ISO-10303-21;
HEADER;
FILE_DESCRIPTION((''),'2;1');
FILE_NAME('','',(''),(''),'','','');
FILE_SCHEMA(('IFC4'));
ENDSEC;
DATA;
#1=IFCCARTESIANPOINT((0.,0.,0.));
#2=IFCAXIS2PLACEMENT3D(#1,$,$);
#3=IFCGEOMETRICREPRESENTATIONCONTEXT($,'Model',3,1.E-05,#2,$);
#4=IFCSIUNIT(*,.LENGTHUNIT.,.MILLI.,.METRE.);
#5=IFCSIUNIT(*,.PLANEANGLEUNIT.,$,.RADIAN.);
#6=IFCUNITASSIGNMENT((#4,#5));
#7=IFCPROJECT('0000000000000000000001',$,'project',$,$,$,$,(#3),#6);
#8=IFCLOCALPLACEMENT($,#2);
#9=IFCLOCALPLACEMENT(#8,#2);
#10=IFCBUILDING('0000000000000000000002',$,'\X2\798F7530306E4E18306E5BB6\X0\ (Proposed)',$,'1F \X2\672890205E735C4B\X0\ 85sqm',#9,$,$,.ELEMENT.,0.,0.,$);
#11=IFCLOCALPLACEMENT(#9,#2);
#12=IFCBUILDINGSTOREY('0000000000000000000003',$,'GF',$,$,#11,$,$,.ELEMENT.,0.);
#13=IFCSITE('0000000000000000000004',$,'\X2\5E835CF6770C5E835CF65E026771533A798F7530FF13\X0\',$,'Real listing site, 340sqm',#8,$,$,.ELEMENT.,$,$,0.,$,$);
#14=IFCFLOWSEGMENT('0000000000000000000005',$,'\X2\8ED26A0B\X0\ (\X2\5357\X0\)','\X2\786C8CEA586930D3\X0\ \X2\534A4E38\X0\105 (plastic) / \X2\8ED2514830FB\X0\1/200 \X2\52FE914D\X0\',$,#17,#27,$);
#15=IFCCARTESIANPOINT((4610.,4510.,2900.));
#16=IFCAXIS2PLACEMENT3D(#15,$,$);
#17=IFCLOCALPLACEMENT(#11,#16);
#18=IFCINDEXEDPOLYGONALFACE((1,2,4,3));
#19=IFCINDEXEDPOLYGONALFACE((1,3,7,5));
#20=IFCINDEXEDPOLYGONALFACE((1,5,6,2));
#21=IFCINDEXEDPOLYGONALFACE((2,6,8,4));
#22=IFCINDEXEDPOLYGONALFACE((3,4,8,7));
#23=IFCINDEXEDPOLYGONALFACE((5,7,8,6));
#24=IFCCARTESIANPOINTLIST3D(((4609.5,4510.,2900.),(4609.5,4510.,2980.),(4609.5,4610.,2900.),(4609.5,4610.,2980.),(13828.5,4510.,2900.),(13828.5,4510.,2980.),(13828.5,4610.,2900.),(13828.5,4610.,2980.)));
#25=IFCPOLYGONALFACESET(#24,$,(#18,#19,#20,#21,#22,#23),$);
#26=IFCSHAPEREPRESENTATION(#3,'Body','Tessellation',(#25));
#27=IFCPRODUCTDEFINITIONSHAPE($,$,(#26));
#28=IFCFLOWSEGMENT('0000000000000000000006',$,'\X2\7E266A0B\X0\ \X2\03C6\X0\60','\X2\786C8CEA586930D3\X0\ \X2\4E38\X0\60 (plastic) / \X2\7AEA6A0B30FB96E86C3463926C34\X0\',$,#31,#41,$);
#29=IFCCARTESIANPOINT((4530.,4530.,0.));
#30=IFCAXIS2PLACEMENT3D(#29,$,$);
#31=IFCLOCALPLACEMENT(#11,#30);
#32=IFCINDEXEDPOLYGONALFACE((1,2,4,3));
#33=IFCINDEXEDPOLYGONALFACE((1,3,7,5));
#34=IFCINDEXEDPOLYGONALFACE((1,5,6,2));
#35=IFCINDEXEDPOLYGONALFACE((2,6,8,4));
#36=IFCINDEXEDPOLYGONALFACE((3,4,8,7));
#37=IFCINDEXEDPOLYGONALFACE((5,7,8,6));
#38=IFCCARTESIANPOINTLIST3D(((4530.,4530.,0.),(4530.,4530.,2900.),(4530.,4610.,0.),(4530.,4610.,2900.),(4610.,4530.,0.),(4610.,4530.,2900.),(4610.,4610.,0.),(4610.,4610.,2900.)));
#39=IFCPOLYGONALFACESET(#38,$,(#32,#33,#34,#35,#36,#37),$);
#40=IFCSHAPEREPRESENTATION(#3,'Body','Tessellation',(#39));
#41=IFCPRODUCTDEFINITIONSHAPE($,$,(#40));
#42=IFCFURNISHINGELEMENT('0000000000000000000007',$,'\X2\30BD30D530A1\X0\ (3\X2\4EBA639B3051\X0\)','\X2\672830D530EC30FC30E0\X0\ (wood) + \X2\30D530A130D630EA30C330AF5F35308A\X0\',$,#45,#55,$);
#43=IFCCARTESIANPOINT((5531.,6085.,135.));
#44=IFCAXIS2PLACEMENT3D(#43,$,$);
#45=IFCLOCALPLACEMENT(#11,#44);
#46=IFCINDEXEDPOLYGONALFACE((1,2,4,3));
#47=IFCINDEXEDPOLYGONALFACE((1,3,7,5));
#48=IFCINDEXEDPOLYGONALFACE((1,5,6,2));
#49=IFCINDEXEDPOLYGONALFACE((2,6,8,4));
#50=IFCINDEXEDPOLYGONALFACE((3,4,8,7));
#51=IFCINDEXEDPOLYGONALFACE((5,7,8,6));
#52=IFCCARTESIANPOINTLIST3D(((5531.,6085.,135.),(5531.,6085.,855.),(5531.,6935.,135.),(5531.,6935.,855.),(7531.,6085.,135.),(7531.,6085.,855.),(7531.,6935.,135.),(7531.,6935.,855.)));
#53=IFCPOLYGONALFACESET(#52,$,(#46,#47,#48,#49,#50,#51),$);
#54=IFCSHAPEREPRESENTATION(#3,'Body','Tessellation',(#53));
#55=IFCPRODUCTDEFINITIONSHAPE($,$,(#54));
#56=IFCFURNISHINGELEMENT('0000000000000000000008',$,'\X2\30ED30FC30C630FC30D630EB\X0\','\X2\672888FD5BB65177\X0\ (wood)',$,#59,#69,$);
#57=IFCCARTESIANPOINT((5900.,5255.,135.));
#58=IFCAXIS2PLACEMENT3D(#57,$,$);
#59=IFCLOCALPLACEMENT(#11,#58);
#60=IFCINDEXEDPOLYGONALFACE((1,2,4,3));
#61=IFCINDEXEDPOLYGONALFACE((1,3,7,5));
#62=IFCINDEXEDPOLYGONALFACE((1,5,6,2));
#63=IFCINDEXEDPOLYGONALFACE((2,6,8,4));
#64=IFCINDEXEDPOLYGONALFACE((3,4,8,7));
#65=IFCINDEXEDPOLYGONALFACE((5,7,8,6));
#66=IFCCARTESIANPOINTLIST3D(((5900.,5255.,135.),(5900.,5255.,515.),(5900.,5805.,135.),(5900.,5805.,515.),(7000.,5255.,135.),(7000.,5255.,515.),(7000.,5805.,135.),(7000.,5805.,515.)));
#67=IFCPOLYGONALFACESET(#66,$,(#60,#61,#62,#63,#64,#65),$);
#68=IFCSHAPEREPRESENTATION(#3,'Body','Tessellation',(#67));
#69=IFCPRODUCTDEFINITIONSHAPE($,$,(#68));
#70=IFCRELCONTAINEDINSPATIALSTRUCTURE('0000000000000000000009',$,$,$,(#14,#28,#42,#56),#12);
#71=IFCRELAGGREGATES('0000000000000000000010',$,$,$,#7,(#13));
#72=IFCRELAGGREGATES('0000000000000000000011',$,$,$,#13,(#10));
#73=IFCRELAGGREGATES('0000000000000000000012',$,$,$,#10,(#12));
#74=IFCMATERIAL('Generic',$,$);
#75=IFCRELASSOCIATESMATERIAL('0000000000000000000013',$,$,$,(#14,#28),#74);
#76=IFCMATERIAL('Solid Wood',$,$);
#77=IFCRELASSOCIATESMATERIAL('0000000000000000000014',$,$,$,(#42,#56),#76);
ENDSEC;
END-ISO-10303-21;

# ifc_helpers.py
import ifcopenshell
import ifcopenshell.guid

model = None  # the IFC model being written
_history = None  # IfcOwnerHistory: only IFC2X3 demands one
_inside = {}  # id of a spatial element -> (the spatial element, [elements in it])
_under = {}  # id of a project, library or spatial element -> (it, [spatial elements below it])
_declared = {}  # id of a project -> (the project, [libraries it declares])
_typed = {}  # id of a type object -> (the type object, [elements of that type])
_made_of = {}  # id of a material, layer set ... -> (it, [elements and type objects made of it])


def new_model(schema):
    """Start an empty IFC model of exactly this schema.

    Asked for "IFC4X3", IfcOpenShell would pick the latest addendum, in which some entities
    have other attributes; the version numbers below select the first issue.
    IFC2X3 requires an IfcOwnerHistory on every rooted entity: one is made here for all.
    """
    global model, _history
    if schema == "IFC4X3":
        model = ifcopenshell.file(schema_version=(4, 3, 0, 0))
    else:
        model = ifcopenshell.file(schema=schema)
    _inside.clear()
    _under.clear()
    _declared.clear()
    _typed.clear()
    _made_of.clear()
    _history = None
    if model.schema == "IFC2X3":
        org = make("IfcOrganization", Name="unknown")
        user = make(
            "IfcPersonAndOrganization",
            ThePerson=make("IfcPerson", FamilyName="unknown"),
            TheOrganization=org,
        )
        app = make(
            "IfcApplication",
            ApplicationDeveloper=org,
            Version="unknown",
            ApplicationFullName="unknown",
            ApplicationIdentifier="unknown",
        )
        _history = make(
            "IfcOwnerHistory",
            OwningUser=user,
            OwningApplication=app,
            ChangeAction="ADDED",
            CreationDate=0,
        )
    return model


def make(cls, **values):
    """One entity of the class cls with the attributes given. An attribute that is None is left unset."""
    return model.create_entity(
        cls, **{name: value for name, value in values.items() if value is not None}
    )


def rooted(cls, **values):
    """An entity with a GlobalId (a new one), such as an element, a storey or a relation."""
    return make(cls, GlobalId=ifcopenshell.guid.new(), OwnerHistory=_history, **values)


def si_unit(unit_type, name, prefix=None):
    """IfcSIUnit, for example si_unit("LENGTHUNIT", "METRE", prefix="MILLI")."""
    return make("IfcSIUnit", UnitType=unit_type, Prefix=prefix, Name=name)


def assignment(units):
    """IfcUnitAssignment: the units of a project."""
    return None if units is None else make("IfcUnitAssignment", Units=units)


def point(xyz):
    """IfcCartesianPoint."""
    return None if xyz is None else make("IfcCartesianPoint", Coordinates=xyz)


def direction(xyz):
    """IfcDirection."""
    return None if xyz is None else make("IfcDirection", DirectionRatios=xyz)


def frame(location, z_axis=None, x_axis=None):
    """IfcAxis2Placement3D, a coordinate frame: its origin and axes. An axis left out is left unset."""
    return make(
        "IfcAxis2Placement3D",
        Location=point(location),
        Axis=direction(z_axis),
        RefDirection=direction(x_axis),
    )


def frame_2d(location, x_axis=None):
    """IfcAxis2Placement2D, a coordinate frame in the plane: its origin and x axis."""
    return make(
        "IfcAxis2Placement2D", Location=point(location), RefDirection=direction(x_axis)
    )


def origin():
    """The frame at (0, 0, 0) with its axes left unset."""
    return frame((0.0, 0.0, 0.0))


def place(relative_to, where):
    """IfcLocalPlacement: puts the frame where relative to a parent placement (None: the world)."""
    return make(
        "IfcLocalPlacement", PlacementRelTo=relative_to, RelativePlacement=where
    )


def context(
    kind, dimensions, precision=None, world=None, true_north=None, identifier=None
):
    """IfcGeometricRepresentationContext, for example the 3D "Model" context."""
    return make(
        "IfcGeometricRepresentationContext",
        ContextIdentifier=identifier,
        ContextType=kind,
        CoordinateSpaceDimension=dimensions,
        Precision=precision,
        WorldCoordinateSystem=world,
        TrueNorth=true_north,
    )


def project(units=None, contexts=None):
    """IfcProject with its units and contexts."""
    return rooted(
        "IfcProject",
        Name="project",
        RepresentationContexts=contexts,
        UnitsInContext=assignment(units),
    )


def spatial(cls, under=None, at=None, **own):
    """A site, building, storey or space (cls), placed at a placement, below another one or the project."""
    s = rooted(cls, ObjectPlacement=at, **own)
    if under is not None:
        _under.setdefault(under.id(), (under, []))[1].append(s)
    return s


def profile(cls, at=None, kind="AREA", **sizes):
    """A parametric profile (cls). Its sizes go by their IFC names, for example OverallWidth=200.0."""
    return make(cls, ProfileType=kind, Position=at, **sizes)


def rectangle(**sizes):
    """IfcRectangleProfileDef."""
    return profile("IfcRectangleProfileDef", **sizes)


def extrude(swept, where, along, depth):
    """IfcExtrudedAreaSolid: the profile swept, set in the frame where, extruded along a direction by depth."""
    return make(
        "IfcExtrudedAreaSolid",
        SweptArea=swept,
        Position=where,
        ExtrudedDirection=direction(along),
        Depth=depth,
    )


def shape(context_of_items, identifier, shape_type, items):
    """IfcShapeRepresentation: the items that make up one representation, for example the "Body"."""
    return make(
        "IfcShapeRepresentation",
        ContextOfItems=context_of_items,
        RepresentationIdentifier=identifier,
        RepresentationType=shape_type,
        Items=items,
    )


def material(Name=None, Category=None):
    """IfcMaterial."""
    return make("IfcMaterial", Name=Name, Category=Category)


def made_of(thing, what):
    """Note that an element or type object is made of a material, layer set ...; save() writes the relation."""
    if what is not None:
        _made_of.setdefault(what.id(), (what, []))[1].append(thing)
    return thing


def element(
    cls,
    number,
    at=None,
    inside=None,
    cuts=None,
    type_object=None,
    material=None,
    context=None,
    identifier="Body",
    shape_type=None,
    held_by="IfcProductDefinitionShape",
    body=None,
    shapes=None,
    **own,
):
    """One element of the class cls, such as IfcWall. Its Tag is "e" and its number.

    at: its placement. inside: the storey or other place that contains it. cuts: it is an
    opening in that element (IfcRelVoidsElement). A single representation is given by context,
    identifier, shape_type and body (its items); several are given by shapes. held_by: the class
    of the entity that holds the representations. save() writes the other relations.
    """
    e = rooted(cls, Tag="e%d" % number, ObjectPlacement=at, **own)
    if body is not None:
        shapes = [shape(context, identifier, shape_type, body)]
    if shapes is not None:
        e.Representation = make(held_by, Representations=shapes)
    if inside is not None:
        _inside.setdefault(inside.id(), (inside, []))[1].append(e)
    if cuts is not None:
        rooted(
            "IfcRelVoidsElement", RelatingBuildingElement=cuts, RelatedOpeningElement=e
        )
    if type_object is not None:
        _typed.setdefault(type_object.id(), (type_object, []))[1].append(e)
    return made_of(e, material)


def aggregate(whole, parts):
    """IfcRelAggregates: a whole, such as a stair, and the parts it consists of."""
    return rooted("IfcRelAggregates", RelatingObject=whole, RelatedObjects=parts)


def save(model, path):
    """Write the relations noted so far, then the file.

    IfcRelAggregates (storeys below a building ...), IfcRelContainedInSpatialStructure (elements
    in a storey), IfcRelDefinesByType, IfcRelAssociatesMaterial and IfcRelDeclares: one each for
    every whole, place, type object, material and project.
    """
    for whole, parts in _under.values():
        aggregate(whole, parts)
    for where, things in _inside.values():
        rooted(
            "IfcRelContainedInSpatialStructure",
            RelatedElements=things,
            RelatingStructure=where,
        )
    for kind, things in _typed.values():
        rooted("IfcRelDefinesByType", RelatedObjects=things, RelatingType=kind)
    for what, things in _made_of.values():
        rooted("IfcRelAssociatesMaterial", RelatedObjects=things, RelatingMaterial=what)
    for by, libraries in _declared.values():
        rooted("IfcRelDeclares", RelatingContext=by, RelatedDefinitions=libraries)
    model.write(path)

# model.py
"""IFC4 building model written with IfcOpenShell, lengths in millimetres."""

from ifc_helpers import new_model, si_unit, frame, frame_2d, origin, place, context, project, spatial, rectangle, extrude, material, element, save


model = new_model("IFC4")

# Units and contexts
model_context = context("Model", 3, precision=1e-05, world=origin())
ifc_project = project(units=[si_unit("LENGTHUNIT", "METRE", prefix="MILLI"), si_unit("PLANEANGLEUNIT", "RADIAN")], contexts=[model_context])

# Site, building, storey
site_placement = place(None, origin())
site = spatial("IfcSite", under=ifc_project, at=site_placement, Name="広島県広島市東区福田３", ObjectType="Real listing site, 340sqm", CompositionType="ELEMENT", RefElevation=0.0)
building_placement = place(site_placement, origin())
building = spatial("IfcBuilding", under=site, at=building_placement, Name="福田の丘の家 (Proposed)", ObjectType="1F 木造平屋 85sqm", CompositionType="ELEMENT", ElevationOfRefHeight=0.0, ElevationOfTerrain=0.0)
storey_placement = place(building_placement, origin())
storey = spatial("IfcBuildingStorey", under=building, at=storey_placement, Name="GF", CompositionType="ELEMENT", Elevation=0.0)

# Shared definitions
ifc_material_1 = material(Name="Solid Wood")

# Shared definitions
ifc_material_2 = material(Name="Generic")

# Flow segments
flow_segment_1_placement = place(storey_placement, frame((4610.0, 4510.0, 2900.0)))
element("IfcFlowSegment", 1, at=flow_segment_1_placement, inside=storey, material=ifc_material_2, Name="軒樋 (南)", Description="硬質塩ビ 半丸105 (plastic) / 軒先・1/200 勾配", context=model_context, shape_type="SweptSolid", body=[
    extrude(rectangle(XDim=9219.0, YDim=100.0, at=frame_2d((4609.0, 50.0))), frame((4610.0, 4510.0, 2900.0)), (0.0, 0.0, 1.0), 80.0),
])
flow_segment_2_placement = place(storey_placement, frame((4530.0, 4530.0, 0.0)))
element("IfcFlowSegment", 2, at=flow_segment_2_placement, inside=storey, material=ifc_material_2, Name="縦樋 φ60", Description="硬質塩ビ 丸60 (plastic) / 竪樋・雨水排水", context=model_context, shape_type="SweptSolid", body=[
    extrude(rectangle(XDim=80.0, YDim=80.0, at=frame_2d((40.0, 40.0))), frame((4530.0, 4530.0, 0.0)), (0.0, 0.0, 1.0), 2900.0),
])

# Furnishing elements
furnishing_1_placement = place(storey_placement, frame((5531.0, 6085.0, 135.0)))
element("IfcFurnishingElement", 3, at=furnishing_1_placement, inside=storey, material=ifc_material_1, Name="ソファ (3人掛け)", Description="木フレーム (wood) + ファブリック張り", context=model_context, shape_type="SweptSolid", body=[
    extrude(rectangle(XDim=2000.0, YDim=850.0, at=frame_2d((1000.0, 425.0))), frame((5531.0, 6085.0, 135.0)), (0.0, 0.0, 1.0), 720.0),
])
furnishing_2_placement = place(storey_placement, frame((5900.0, 5255.0, 135.0)))
element("IfcFurnishingElement", 4, at=furnishing_2_placement, inside=storey, material=ifc_material_1, Name="ローテーブル", Description="木製家具 (wood)", context=model_context, shape_type="SweptSolid", body=[
    extrude(rectangle(XDim=1100.0, YDim=550.0, at=frame_2d((550.0, 275.0))), frame((5900.0, 5255.0, 135.0)), (0.0, 0.0, 1.0), 380.0),
])

save(model, "model.ifc")
